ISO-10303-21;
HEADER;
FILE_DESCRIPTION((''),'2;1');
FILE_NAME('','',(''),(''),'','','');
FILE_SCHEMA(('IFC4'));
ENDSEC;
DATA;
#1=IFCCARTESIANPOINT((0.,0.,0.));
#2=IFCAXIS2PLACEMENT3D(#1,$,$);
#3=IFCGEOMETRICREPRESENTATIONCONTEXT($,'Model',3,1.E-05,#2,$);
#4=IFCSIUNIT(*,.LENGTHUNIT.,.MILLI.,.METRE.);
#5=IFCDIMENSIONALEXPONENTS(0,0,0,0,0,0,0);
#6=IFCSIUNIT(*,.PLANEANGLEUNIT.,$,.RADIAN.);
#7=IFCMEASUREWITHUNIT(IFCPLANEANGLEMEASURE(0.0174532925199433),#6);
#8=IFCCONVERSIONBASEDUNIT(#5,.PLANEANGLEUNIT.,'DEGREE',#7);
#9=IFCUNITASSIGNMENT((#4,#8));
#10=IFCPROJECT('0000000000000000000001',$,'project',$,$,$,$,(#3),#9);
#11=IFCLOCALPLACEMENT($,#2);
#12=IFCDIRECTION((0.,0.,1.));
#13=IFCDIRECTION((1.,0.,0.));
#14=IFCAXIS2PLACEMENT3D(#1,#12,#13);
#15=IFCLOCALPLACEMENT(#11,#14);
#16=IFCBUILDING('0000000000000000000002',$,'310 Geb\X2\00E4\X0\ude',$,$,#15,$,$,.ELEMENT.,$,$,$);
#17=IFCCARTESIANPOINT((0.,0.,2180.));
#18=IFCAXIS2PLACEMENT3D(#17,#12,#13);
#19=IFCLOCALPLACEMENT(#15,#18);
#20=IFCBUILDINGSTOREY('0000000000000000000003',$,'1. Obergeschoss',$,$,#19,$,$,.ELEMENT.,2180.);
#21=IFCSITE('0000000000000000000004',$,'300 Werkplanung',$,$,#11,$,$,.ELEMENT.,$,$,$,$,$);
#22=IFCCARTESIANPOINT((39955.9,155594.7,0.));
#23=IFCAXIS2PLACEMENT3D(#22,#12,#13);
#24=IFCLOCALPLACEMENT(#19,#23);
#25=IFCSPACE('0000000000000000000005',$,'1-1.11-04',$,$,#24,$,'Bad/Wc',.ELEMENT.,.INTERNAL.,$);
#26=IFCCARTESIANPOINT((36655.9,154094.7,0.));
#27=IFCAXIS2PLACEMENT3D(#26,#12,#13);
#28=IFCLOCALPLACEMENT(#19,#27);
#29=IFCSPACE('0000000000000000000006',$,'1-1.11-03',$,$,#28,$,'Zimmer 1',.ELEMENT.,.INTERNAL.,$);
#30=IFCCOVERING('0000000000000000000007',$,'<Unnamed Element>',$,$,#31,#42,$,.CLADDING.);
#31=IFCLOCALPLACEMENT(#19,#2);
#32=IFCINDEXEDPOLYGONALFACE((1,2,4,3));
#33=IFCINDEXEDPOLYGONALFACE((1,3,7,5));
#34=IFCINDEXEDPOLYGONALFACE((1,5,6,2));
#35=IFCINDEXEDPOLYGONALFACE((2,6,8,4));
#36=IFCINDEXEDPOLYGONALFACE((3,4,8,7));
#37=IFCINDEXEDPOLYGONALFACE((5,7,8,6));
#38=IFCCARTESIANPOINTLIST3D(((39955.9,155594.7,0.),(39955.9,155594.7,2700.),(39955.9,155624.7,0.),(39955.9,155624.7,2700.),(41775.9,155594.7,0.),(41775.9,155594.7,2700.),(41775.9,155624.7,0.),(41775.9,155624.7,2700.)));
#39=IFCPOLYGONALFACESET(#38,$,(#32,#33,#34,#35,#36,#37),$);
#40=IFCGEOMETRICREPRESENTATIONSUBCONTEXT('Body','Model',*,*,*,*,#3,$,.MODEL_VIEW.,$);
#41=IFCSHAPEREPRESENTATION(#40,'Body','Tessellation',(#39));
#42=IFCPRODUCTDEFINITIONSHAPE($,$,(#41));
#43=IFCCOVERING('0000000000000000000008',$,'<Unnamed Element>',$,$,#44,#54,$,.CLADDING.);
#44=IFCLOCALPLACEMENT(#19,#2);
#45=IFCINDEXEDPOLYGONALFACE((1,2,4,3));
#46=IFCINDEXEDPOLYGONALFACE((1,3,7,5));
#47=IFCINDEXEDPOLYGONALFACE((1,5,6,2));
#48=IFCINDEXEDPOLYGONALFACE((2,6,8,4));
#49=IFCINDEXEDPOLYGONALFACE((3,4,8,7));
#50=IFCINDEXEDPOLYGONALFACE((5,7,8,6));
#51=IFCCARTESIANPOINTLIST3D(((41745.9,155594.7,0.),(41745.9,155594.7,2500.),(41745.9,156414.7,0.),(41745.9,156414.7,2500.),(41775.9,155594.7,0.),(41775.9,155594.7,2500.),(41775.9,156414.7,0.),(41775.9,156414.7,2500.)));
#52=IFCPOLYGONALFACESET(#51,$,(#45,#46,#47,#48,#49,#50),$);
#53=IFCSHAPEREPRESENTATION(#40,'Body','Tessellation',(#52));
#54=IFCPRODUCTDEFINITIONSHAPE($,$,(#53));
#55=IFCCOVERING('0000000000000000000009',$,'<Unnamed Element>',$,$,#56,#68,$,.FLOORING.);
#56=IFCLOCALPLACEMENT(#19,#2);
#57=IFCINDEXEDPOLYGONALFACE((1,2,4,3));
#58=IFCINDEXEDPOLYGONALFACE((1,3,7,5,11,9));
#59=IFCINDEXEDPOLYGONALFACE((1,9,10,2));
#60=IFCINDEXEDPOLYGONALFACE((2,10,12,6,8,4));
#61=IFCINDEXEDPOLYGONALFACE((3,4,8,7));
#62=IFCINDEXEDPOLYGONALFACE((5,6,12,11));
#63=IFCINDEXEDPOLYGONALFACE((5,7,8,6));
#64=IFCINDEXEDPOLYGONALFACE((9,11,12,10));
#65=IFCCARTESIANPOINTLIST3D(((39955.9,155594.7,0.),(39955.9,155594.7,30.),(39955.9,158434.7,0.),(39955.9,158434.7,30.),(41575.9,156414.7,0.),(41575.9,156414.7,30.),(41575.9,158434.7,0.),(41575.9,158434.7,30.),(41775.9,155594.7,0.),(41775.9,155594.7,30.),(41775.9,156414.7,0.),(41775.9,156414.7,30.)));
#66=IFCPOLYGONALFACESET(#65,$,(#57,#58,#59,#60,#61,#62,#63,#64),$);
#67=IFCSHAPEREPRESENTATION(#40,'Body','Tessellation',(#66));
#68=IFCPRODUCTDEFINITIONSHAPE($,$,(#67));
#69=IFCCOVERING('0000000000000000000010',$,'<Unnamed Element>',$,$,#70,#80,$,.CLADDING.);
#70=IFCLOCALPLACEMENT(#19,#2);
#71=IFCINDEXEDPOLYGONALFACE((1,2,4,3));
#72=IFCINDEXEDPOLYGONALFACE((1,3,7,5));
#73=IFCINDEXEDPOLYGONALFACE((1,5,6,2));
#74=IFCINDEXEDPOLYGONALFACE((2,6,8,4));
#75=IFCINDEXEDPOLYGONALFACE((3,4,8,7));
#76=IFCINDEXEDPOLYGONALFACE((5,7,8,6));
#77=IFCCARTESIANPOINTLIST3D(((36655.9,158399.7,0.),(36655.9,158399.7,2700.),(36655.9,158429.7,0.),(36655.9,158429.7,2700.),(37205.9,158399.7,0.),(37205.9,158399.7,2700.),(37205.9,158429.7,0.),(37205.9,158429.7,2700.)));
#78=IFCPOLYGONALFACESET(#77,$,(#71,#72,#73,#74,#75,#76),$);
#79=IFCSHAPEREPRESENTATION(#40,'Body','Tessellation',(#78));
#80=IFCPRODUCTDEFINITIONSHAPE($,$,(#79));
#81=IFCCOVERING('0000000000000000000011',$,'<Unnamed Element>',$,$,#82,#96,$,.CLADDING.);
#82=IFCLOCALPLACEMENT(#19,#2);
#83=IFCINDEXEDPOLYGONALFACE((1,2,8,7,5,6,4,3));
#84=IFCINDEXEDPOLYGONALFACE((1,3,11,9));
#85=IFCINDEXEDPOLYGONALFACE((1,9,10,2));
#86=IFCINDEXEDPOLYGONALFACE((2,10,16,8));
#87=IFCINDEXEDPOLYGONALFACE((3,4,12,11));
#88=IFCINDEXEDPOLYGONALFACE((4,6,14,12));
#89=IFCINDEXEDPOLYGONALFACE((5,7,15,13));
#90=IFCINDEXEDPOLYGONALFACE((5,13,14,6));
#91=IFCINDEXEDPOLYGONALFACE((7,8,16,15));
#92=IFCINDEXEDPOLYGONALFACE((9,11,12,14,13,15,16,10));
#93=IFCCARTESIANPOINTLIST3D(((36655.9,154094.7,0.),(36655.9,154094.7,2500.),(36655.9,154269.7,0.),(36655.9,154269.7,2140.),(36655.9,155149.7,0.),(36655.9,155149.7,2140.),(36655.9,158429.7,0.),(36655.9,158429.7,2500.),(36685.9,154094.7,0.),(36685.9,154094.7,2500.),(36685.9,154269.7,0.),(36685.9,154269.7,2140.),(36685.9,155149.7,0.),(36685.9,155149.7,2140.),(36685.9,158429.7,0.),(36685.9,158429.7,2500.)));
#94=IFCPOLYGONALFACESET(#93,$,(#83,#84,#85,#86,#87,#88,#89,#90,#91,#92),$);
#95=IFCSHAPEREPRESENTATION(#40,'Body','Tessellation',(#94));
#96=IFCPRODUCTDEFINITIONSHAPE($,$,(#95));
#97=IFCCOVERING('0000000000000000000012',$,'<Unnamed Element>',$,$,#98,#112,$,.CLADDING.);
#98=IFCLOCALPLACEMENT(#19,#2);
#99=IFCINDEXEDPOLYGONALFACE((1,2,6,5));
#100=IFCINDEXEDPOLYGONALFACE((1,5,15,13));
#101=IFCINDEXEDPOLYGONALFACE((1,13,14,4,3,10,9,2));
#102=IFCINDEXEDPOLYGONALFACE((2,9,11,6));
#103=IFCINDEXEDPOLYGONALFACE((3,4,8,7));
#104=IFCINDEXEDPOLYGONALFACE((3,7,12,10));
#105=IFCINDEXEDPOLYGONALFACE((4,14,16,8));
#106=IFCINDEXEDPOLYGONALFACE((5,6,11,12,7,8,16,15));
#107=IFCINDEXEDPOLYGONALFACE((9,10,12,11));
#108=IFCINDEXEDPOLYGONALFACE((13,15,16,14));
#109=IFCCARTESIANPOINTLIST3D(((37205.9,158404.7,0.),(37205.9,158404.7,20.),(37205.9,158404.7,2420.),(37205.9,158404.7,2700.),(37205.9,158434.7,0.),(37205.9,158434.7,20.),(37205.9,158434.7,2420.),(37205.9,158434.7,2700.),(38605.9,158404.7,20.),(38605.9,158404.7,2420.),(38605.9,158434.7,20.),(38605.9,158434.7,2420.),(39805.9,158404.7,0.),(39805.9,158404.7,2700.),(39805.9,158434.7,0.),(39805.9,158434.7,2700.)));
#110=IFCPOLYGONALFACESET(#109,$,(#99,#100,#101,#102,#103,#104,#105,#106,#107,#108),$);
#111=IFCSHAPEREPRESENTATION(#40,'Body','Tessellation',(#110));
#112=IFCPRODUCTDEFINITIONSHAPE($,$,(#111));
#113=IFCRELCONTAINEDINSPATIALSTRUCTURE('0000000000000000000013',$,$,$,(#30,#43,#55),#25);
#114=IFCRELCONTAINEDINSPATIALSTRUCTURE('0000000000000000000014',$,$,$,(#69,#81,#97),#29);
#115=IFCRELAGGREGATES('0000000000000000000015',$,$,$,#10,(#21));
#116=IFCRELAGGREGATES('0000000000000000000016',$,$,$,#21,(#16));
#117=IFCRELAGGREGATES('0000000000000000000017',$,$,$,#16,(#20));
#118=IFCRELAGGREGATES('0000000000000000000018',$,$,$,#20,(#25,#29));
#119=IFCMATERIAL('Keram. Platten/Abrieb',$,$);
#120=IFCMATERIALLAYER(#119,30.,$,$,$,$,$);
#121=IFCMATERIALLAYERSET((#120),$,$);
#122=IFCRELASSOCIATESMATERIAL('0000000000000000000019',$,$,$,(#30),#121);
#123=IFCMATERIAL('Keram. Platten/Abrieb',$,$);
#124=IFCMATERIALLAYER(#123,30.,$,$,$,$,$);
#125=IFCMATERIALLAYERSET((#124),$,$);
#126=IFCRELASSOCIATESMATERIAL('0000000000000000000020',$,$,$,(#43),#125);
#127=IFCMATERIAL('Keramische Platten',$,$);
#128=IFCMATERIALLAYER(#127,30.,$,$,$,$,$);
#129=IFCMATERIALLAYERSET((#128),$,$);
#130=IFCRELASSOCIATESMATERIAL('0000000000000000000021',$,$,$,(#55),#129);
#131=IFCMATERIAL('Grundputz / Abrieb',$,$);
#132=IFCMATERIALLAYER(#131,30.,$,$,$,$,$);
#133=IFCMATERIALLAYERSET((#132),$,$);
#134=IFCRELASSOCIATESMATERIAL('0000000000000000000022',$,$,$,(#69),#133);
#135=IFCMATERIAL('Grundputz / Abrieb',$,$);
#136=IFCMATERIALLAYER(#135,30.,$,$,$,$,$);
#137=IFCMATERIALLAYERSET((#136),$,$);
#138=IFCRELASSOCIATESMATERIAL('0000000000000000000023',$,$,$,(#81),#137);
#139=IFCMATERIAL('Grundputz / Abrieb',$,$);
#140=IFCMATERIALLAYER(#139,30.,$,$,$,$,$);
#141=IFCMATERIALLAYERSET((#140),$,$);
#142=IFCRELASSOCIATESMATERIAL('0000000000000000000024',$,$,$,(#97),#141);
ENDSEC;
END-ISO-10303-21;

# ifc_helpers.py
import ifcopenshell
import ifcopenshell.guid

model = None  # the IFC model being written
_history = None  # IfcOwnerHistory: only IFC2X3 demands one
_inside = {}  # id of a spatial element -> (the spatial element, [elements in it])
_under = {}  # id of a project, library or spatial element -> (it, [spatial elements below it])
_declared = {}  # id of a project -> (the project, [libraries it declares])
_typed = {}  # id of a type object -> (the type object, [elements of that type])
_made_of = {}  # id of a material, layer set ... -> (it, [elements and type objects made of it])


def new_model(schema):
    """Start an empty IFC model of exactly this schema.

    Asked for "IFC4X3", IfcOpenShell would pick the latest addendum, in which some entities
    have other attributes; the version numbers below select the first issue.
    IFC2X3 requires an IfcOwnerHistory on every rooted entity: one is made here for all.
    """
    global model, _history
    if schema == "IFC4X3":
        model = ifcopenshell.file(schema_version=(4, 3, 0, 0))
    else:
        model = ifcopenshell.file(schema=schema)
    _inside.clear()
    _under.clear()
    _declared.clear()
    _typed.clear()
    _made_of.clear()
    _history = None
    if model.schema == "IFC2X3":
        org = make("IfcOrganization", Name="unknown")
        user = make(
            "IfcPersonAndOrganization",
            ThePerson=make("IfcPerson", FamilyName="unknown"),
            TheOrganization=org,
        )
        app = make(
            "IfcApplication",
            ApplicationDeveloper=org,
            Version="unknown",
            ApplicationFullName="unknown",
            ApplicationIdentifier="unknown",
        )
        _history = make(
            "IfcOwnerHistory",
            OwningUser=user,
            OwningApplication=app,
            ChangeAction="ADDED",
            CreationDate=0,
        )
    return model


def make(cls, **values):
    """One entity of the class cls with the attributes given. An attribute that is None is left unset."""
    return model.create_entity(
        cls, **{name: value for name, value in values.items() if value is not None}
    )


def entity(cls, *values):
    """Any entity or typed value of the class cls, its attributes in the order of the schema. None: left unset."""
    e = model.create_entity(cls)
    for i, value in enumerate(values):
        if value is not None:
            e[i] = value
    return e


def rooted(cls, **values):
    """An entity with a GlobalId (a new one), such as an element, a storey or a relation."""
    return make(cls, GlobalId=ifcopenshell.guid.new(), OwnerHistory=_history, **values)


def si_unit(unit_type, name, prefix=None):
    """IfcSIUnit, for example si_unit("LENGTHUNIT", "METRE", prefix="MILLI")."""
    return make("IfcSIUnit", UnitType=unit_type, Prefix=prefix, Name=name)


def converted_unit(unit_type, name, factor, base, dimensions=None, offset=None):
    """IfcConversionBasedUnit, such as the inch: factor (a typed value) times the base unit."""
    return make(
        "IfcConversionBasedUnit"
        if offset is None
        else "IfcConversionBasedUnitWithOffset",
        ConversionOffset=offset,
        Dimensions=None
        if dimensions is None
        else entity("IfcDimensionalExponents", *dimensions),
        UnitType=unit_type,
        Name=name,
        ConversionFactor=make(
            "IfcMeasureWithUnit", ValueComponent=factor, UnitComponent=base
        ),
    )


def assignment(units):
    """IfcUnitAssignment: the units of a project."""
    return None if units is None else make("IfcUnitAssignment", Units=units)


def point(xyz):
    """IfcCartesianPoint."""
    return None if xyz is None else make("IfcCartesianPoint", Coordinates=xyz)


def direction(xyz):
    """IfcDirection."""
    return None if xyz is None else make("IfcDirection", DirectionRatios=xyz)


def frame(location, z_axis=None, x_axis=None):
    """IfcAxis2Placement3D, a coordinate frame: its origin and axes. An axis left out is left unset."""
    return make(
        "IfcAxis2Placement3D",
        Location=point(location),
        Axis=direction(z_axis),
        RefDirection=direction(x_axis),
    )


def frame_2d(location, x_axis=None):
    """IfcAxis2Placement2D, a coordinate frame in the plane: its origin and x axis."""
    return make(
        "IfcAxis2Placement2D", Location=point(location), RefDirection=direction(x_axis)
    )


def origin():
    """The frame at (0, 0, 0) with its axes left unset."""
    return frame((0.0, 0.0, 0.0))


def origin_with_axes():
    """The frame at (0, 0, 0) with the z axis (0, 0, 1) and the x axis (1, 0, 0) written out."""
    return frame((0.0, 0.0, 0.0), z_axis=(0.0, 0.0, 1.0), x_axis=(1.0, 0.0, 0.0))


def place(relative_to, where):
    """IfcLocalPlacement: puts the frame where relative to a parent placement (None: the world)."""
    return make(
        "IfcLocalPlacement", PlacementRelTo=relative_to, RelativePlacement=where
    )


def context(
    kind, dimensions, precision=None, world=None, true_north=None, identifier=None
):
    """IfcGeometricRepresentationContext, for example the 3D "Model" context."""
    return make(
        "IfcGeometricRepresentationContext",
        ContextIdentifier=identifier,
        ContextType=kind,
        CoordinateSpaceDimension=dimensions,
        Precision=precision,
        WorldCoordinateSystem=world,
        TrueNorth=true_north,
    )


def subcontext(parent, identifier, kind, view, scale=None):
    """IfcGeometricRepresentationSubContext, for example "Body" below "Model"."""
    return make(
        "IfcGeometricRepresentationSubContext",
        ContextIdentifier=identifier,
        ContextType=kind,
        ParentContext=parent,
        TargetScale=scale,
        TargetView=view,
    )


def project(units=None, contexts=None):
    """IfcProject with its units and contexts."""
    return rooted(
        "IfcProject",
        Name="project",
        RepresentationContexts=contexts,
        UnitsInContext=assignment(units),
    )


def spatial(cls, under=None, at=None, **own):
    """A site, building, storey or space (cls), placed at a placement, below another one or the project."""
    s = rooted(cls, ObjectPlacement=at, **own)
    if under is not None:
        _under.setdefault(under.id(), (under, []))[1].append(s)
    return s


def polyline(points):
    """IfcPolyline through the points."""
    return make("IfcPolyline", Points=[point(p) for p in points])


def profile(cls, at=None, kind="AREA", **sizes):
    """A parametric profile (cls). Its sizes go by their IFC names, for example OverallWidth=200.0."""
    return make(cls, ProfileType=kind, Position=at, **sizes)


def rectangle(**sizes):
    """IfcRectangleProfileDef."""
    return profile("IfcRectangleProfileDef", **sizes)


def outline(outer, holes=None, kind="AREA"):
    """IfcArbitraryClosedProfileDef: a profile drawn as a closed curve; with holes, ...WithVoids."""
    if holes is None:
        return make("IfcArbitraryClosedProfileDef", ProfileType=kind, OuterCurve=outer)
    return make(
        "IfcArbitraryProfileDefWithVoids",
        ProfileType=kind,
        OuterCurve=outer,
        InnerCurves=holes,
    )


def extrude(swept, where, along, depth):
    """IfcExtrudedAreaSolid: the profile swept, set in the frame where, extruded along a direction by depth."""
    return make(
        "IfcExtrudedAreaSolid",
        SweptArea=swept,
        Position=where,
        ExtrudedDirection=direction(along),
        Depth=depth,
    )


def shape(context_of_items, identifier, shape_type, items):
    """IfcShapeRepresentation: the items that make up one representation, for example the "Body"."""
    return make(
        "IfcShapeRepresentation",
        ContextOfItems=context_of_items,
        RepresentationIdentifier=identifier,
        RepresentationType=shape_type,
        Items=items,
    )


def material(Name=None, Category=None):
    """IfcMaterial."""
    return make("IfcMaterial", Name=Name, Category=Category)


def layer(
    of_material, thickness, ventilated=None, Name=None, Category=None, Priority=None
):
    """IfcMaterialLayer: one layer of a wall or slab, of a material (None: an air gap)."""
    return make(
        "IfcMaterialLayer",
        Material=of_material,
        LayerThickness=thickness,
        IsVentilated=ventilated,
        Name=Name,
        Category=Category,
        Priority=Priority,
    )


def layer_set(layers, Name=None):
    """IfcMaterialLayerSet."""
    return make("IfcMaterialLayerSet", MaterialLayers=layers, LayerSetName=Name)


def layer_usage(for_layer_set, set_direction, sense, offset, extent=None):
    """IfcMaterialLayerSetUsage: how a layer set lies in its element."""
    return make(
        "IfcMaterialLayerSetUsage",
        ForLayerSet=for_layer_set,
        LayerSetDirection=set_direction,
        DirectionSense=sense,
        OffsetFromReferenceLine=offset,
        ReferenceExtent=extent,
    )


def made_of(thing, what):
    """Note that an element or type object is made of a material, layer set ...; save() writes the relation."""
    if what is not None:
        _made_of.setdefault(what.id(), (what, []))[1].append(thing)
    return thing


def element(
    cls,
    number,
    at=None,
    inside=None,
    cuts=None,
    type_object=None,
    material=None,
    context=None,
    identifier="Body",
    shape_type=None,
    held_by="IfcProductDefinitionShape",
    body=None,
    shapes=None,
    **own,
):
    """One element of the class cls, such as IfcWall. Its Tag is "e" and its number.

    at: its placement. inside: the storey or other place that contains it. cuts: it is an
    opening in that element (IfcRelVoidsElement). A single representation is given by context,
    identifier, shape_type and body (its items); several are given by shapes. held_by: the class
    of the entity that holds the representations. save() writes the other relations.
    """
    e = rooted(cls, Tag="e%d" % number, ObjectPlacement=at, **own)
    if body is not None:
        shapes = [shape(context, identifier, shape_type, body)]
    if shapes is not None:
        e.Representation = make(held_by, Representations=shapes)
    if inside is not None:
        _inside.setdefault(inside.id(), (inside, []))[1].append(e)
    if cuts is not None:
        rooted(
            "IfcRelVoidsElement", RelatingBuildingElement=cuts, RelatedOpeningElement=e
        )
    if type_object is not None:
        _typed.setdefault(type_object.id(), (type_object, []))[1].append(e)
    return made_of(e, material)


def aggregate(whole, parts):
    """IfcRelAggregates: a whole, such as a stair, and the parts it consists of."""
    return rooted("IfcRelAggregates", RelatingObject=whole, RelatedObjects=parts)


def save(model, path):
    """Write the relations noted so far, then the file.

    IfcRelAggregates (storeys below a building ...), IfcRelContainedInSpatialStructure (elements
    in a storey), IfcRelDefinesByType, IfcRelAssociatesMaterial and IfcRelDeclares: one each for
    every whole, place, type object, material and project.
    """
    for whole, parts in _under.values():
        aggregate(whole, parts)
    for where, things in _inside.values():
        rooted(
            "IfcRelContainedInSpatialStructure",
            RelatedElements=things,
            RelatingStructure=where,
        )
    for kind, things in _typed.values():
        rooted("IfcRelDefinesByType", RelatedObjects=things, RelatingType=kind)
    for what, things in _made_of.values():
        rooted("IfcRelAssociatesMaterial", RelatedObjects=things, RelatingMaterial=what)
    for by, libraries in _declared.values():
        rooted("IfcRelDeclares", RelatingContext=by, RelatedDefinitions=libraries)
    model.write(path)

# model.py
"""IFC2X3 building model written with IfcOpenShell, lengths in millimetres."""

from ifc_helpers import new_model, entity, si_unit, converted_unit, frame, frame_2d, origin, origin_with_axes, place, context, subcontext, project, spatial, polyline, rectangle, outline, extrude, material, layer, layer_set, layer_usage, element, save


model = new_model("IFC2X3")

# Units and contexts
model_context = context("Model", 3, precision=1e-05, world=origin())
body_context = subcontext(model_context, "Body", "Model", "MODEL_VIEW")
ifc_project = project(units=[si_unit("LENGTHUNIT", "METRE", prefix="MILLI"), converted_unit("PLANEANGLEUNIT", "DEGREE", entity("IfcPlaneAngleMeasure", 0.0174532925199433), si_unit("PLANEANGLEUNIT", "RADIAN"), dimensions=[0, 0, 0, 0, 0, 0, 0])], contexts=[model_context])

# Site, building, storey
site_placement = place(None, origin())
site = spatial("IfcSite", under=ifc_project, at=site_placement, Name="300 Werkplanung", CompositionType="ELEMENT")
building_placement = place(site_placement, origin_with_axes())
building = spatial("IfcBuilding", under=site, at=building_placement, Name="310 Gebäude", CompositionType="ELEMENT")
storey_placement = place(building_placement, frame((0.0, 0.0, 2180.0), z_axis=(0.0, 0.0, 1.0), x_axis=(1.0, 0.0, 0.0)))
storey = spatial("IfcBuildingStorey", under=building, at=storey_placement, Name="1. Obergeschoss", CompositionType="ELEMENT", Elevation=2180.0)

# Shared definitions
space_1_placement = place(storey_placement, frame((39955.9, 155594.7, 0.0), z_axis=(0.0, 0.0, 1.0), x_axis=(1.0, 0.0, 0.0)))
space_1 = spatial("IfcSpace", under=storey, at=space_1_placement, Name="1-1.11-04", LongName="Bad/Wc", CompositionType="ELEMENT", InteriorOrExteriorSpace="INTERNAL")

# Coverings
ifc_material_1 = material(Name="Keram. Platten/Abrieb")
ifc_layer_1 = layer(ifc_material_1, 30.0)
ifc_layer_set_1 = layer_set([ifc_layer_1])
ifc_layer_usage_1 = layer_usage(ifc_layer_set_1, "AXIS3", "POSITIVE", 0.0)
covering_1_placement = place(space_1_placement, origin_with_axes())
element("IfcCovering", 1, at=covering_1_placement, inside=space_1, material=ifc_layer_usage_1, Name="<Unnamed Element>", PredefinedType="CLADDING", context=body_context, shape_type="SweptSolid", body=[
    extrude(rectangle(XDim=2700.0, YDim=1820.0, at=frame_2d((-910.0, 1350.0), x_axis=(0.0, 1.0))), frame((1820.0, 0.0, 2700.0), z_axis=(0.0, 1.0, 0.0), x_axis=(1.0, 0.0, 0.0)), (0.0, 0.0, 1.0), 30.0),
])
ifc_material_2 = material(Name="Keram. Platten/Abrieb")
ifc_layer_2 = layer(ifc_material_2, 30.0)
ifc_layer_set_2 = layer_set([ifc_layer_2])
ifc_layer_usage_2 = layer_usage(ifc_layer_set_2, "AXIS3", "POSITIVE", 0.0)
covering_2_placement = place(space_1_placement, frame((1820.0, 0.0, 0.0), z_axis=(0.0, 0.0, 1.0), x_axis=(0.0, 1.0, 0.0)))
element("IfcCovering", 2, at=covering_2_placement, inside=space_1, material=ifc_layer_usage_2, Name="<Unnamed Element>", PredefinedType="CLADDING", context=body_context, shape_type="SweptSolid", body=[
    extrude(rectangle(XDim=2500.0, YDim=820.0, at=frame_2d((-410.0, 1250.0), x_axis=(0.0, 1.0))), frame((820.0, 0.0, 2500.0), z_axis=(0.0, 1.0, 0.0), x_axis=(1.0, 0.0, 0.0)), (0.0, 0.0, 1.0), 30.0),
])
ifc_material_3 = material(Name="Keramische Platten")
ifc_layer_3 = layer(ifc_material_3, 30.0)
ifc_layer_set_3 = layer_set([ifc_layer_3])
ifc_layer_usage_3 = layer_usage(ifc_layer_set_3, "AXIS3", "POSITIVE", 0.0)
covering_3_placement = place(space_1_placement, origin_with_axes())
element("IfcCovering", 3, at=covering_3_placement, inside=space_1, material=ifc_layer_usage_3, Name="<Unnamed Element>", PredefinedType="FLOORING", context=body_context, shape_type="SweptSolid", body=[
    extrude(outline(polyline([(1620.0, 2840.0), (0.0, 2840.0), (0.0, 0.0), (1820.0, 0.0), (1820.0, 820.0), (1620.0, 820.0), (1620.0, 2840.0)])), origin_with_axes(), (0.0, 0.0, 1.0), 30.0),
])

# Shared definitions
space_2_placement = place(storey_placement, frame((36655.9, 154094.7, 0.0), z_axis=(0.0, 0.0, 1.0), x_axis=(1.0, 0.0, 0.0)))
space_2 = spatial("IfcSpace", under=storey, at=space_2_placement, Name="1-1.11-03", LongName="Zimmer 1", CompositionType="ELEMENT", InteriorOrExteriorSpace="INTERNAL")

# Coverings
ifc_material_4 = material(Name="Grundputz / Abrieb")
ifc_layer_4 = layer(ifc_material_4, 30.0)
ifc_layer_set_4 = layer_set([ifc_layer_4])
ifc_layer_usage_4 = layer_usage(ifc_layer_set_4, "AXIS3", "POSITIVE", 0.0)
covering_4_placement = place(space_2_placement, frame((550.0, 4335.0, 0.0), z_axis=(0.0, 0.0, 1.0), x_axis=(-1.0, 0.0, 0.0)))
element("IfcCovering", 4, at=covering_4_placement, inside=space_2, material=ifc_layer_usage_4, Name="<Unnamed Element>", PredefinedType="CLADDING", context=body_context, shape_type="SweptSolid", body=[
    extrude(rectangle(XDim=2700.0, YDim=550.0, at=frame_2d((-275.0, 1350.0), x_axis=(0.0, 1.0))), frame((550.0, 0.0, 2700.0), z_axis=(0.0, 1.0, 0.0), x_axis=(1.0, 0.0, 0.0)), (0.0, 0.0, 1.0), 30.0),
])
ifc_material_5 = material(Name="Grundputz / Abrieb")
ifc_layer_5 = layer(ifc_material_5, 30.0)
ifc_layer_set_5 = layer_set([ifc_layer_5])
ifc_layer_usage_5 = layer_usage(ifc_layer_set_5, "AXIS3", "POSITIVE", 0.0)
covering_5_placement = place(space_2_placement, frame((0.0, 4335.0, 0.0), z_axis=(0.0, 0.0, 1.0), x_axis=(0.0, -1.0, 0.0)))
element("IfcCovering", 5, at=covering_5_placement, inside=space_2, material=ifc_layer_usage_5, Name="<Unnamed Element>", PredefinedType="CLADDING", context=body_context, shape_type="SweptSolid", body=[
    extrude(outline(polyline([(4335.0, 0.0), (4335.0, -2500.0), (0.0, -2500.0), (0.0, 0.0), (3280.0, 0.0), (3280.0, -2140.0), (4160.0, -2140.0), (4160.0, 0.0), (4335.0, 0.0)])), frame((0.0, 0.0, 0.0), z_axis=(0.0, 1.0, 0.0), x_axis=(1.0, 0.0, 0.0)), (0.0, 0.0, 1.0), 30.0),
])
ifc_material_6 = material(Name="Grundputz / Abrieb")
ifc_layer_6 = layer(ifc_material_6, 30.0)
ifc_layer_set_6 = layer_set([ifc_layer_6])
ifc_layer_usage_6 = layer_usage(ifc_layer_set_6, "AXIS3", "POSITIVE", 0.0)
covering_6_placement = place(space_2_placement, frame((3150.0, 4340.0, 0.0), z_axis=(0.0, 0.0, 1.0), x_axis=(-1.0, 0.0, 0.0)))
element("IfcCovering", 6, at=covering_6_placement, inside=space_2, material=ifc_layer_usage_6, Name="<Unnamed Element>", PredefinedType="CLADDING", context=body_context, shape_type="SweptSolid", body=[
    extrude(outline(polyline([(2600.0, 0.0), (2600.0, -20.0), (1200.0, -20.0), (1200.0, -2420.0), (2600.0, -2420.0), (2600.0, -2700.0), (0.0, -2700.0), (0.0, 0.0), (2600.0, 0.0)])), frame((0.0, 0.0, 0.0), z_axis=(0.0, 1.0, 0.0), x_axis=(1.0, 0.0, 0.0)), (0.0, 0.0, 1.0), 30.0),
])

save(model, "model.ifc")
